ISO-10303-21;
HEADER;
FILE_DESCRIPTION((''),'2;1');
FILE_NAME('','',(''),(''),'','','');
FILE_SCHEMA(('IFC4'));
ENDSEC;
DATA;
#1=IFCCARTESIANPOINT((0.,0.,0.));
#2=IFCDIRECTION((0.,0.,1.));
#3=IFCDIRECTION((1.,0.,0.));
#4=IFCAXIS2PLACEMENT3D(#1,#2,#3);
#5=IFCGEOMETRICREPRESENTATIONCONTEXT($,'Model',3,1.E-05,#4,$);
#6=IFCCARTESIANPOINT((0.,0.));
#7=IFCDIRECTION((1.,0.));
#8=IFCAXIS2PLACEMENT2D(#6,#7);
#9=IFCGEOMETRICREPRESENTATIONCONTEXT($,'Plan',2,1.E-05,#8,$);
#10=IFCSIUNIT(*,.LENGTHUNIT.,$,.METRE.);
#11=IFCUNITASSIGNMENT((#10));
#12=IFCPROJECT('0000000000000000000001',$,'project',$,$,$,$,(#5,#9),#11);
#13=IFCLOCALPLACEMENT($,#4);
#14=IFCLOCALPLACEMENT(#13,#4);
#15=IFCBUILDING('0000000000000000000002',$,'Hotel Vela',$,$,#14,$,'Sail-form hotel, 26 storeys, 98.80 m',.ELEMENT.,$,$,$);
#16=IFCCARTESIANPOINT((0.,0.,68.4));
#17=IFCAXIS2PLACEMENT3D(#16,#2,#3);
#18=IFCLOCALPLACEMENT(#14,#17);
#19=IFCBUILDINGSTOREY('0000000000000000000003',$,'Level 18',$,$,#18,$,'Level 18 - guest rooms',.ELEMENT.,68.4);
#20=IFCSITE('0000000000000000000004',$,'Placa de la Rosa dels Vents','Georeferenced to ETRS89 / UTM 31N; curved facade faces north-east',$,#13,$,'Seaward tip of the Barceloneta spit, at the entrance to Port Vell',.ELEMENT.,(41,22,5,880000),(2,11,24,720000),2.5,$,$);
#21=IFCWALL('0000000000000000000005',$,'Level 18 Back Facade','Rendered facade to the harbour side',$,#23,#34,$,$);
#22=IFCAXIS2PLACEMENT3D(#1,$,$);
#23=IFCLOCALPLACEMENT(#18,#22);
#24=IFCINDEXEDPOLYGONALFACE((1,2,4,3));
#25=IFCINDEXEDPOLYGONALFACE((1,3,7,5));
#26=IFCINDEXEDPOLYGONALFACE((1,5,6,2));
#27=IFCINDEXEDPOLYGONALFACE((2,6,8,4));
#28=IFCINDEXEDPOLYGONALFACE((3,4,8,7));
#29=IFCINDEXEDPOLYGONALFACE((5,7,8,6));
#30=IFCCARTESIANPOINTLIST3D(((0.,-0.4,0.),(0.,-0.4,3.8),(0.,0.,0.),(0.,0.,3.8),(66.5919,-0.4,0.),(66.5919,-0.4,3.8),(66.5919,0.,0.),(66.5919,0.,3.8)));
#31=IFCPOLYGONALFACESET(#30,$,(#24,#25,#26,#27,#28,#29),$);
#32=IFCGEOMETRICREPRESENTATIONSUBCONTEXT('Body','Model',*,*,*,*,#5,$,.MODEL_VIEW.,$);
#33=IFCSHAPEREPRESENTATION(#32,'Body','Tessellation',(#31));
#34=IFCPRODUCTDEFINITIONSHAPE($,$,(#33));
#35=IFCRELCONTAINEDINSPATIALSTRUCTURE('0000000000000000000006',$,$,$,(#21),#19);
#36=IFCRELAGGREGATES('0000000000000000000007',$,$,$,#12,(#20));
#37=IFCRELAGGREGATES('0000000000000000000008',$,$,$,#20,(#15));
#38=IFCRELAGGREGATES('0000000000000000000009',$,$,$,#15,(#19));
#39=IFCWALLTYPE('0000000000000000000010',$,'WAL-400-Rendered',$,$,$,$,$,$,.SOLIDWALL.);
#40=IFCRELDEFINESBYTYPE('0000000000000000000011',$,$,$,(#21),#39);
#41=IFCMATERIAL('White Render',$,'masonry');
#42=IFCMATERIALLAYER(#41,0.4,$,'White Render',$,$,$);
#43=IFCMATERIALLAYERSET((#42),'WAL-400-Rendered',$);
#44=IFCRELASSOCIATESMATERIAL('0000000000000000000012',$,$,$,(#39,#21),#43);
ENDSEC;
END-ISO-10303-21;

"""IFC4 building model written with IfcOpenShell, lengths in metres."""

from ifc_helpers import new_model, si_unit, frame, origin_with_axes, origin_2d_with_axis, place, context, subcontext, project, spatial, line, indexed_curve, outline, extrude, material, layer, layer_set, layer_usage, type_object, element, save


model = new_model("IFC4")

# Units and contexts
model_context = context("Model", 3, precision=1e-05, world=origin_with_axes())
plan_context = context("Plan", 2, precision=1e-05, world=origin_2d_with_axis())
body_context = subcontext(model_context, "Body", "Model", "MODEL_VIEW")
ifc_project = project(units=[si_unit("LENGTHUNIT", "METRE")], contexts=[model_context, plan_context])

# Site, building, storey
site_placement = place(None, origin_with_axes())
site = spatial("IfcSite", under=ifc_project, at=site_placement, Name="Placa de la Rosa dels Vents", Description="Georeferenced to ETRS89 / UTM 31N; curved facade faces north-east", LongName="Seaward tip of the Barceloneta spit, at the entrance to Port Vell", CompositionType="ELEMENT", RefLatitude=(41, 22, 5, 880000), RefLongitude=(2, 11, 24, 720000), RefElevation=2.5)
building_placement = place(site_placement, origin_with_axes())
building = spatial("IfcBuilding", under=site, at=building_placement, Name="Hotel Vela", LongName="Sail-form hotel, 26 storeys, 98.80 m", CompositionType="ELEMENT")
storey_placement = place(building_placement, frame((0.0, 0.0, 68.4), z_axis=(0.0, 0.0, 1.0), x_axis=(1.0, 0.0, 0.0)))
storey = spatial("IfcBuildingStorey", under=building, at=storey_placement, Name="Level 18", LongName="Level 18 - guest rooms", CompositionType="ELEMENT", Elevation=68.4)

# Wall
ifc_material_1 = material(Name="White Render", Category="masonry")
ifc_layer_1 = layer(ifc_material_1, 0.4, Name="White Render")
ifc_layer_set_1 = layer_set([ifc_layer_1], Name="WAL-400-Rendered")
ifc_layer_usage_1 = layer_usage(ifc_layer_set_1, "AXIS2", "POSITIVE", 0.0)
wall_type = type_object("IfcWallType", Name="WAL-400-Rendered", PredefinedType="SOLIDWALL", material=ifc_layer_set_1)
wall_placement = place(storey_placement, frame((0.0, -0.4, 0.0), z_axis=(0.0, 0.0, 1.0), x_axis=(1.0, 0.0, 0.0)))
element("IfcWall", 1, at=wall_placement, inside=storey, type_object=wall_type, material=ifc_layer_usage_1, Name="Level 18 Back Facade", Description="Rendered facade to the harbour side", context=body_context, shape_type="SweptSolid", body=[
    extrude(outline(indexed_curve([(0.0, 0.0), (66.5919, 0.0), (66.5919, 0.4), (0.0, 0.4)], segments=[line(1, 2, 3, 4, 1)])), origin_with_axes(), (0.0, 0.0, 1.0), 3.8),
])

save(model, "model.ifc")
